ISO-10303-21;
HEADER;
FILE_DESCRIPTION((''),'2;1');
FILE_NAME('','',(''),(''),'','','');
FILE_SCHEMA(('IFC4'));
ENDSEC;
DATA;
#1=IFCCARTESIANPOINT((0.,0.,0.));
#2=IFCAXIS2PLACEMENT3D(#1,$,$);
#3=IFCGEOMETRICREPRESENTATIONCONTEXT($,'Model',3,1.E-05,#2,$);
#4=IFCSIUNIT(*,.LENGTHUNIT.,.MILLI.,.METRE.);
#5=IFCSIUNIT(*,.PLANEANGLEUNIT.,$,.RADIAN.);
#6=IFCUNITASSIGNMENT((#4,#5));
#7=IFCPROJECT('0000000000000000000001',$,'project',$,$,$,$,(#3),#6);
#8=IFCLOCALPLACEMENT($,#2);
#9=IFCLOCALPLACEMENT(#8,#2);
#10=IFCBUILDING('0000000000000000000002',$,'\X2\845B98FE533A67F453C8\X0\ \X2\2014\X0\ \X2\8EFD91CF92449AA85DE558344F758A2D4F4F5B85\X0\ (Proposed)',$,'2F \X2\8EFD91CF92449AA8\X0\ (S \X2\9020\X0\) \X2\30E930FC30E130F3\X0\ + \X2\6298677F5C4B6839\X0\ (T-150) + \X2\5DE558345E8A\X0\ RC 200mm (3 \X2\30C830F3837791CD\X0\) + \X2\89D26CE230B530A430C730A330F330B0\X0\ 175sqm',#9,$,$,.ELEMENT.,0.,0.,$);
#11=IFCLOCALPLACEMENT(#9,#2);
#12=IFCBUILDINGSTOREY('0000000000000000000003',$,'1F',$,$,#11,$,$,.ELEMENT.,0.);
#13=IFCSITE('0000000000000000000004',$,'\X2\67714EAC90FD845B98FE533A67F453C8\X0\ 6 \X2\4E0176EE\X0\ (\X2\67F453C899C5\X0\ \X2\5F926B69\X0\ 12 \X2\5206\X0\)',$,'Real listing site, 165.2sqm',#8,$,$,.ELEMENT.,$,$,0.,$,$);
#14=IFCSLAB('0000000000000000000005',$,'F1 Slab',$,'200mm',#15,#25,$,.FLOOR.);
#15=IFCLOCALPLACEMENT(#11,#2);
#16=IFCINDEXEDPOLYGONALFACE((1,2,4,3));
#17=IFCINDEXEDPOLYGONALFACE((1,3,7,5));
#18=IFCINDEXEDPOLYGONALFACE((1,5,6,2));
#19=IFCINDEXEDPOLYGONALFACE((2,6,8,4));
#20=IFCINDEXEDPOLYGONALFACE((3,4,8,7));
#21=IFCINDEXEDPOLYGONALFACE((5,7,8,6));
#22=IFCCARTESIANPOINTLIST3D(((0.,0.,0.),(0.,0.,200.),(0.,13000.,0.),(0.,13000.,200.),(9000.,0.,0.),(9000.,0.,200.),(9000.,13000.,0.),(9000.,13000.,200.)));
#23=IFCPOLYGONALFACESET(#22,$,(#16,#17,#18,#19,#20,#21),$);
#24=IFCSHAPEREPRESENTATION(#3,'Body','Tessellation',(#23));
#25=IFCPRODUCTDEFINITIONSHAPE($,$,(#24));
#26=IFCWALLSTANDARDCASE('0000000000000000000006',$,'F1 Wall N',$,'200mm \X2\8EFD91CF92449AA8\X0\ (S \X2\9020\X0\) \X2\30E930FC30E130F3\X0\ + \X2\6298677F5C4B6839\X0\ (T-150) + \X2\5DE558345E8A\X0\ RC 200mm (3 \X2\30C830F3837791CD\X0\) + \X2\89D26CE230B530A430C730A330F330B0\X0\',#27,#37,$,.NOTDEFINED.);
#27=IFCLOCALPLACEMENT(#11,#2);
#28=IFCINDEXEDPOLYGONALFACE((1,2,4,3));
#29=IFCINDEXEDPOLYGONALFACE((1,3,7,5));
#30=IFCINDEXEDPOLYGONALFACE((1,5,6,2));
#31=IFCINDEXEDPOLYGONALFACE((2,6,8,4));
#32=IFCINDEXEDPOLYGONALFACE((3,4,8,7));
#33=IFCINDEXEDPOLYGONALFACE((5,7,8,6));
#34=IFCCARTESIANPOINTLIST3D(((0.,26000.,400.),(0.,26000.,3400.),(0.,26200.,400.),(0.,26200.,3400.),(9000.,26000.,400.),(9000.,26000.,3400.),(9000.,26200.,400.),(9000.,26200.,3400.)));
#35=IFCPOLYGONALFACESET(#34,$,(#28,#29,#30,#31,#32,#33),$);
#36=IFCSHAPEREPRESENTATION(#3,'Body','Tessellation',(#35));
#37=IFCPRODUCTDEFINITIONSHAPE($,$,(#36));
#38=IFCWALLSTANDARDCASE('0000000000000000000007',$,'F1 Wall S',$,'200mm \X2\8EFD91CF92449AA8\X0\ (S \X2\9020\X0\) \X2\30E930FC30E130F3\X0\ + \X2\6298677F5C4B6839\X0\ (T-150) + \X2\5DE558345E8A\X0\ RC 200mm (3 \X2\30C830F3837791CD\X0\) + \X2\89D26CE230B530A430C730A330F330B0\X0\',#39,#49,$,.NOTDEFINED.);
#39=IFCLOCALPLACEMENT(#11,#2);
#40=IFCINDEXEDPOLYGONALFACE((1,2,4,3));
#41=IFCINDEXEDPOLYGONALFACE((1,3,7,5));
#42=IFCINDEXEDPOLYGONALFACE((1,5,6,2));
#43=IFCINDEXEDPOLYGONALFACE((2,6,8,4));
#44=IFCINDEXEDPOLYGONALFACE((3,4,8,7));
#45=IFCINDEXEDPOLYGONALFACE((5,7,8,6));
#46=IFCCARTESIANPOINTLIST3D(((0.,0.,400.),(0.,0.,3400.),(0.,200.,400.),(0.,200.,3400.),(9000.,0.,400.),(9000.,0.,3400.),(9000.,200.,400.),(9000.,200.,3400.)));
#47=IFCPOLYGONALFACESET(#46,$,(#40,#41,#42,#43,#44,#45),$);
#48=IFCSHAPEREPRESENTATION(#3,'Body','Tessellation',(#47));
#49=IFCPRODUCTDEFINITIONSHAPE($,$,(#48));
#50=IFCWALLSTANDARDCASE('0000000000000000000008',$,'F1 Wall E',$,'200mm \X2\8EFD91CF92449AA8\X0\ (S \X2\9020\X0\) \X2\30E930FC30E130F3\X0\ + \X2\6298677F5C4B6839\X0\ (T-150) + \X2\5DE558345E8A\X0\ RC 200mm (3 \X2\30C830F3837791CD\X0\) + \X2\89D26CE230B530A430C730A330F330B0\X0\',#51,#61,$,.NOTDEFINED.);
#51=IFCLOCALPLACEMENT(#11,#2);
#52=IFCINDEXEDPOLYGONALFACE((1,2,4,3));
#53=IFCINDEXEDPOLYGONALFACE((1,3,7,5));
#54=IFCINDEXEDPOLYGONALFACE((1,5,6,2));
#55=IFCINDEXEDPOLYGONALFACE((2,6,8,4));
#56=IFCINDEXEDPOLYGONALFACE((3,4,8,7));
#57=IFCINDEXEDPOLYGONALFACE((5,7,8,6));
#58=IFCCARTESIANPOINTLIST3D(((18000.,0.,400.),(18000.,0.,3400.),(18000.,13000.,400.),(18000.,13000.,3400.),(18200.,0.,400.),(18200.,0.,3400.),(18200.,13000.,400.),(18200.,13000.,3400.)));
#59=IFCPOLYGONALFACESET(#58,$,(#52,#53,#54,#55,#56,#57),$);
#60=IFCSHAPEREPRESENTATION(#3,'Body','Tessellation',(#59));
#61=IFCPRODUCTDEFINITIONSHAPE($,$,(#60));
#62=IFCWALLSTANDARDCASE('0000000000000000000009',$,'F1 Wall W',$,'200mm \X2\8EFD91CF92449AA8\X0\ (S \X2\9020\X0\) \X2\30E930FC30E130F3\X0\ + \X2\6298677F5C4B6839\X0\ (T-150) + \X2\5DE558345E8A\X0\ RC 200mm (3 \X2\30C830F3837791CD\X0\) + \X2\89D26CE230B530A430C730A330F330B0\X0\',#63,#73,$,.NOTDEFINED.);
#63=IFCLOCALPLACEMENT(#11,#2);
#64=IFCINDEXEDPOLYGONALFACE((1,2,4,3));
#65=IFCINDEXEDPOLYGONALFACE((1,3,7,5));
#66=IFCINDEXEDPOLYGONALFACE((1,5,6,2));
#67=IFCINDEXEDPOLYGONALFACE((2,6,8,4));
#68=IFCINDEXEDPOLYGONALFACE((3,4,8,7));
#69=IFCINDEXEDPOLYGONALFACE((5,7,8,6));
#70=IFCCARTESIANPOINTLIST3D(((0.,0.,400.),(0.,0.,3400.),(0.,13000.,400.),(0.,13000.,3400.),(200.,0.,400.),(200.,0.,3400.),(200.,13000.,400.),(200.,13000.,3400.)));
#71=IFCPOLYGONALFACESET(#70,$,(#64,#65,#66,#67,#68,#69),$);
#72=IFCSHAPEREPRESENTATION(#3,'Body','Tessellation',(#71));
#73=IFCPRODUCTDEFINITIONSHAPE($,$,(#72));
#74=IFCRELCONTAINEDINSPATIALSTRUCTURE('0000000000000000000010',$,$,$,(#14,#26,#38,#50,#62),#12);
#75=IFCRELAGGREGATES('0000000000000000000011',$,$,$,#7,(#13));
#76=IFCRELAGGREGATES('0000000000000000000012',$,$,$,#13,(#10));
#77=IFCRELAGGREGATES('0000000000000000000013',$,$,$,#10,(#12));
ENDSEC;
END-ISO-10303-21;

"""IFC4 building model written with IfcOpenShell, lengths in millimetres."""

from ifc_helpers import new_model, si_unit, frame, frame_2d, origin, place, context, project, spatial, rectangle, extrude, element, save


model = new_model("IFC4")

# Units and contexts
model_context = context("Model", 3, precision=1e-05, world=origin())
ifc_project = project(units=[si_unit("LENGTHUNIT", "METRE", prefix="MILLI"), si_unit("PLANEANGLEUNIT", "RADIAN")], contexts=[model_context])

# Site, building, storey
site_placement = place(None, origin())
site = spatial("IfcSite", under=ifc_project, at=site_placement, Name="東京都葛飾区柴又 6 丁目 (柴又駅 徒歩 12 分)", ObjectType="Real listing site, 165.2sqm", CompositionType="ELEMENT", RefElevation=0.0)
building_placement = place(site_placement, origin())
building = spatial("IfcBuilding", under=site, at=building_placement, Name="葛飾区柴又 — 軽量鉄骨工場併設住宅 (Proposed)", ObjectType="2F 軽量鉄骨 (S 造) ラーメン + 折板屋根 (T-150) + 工場床 RC 200mm (3 トン荷重) + 角波サイディング 175sqm", CompositionType="ELEMENT", ElevationOfRefHeight=0.0, ElevationOfTerrain=0.0)
storey_placement = place(building_placement, origin())
storey = spatial("IfcBuildingStorey", under=building, at=storey_placement, Name="1F", CompositionType="ELEMENT", Elevation=0.0)

# Slab
slab_placement = place(storey_placement, origin())
element("IfcSlab", 1, at=slab_placement, inside=storey, Name="F1 Slab", ObjectType="200mm", PredefinedType="FLOOR", context=model_context, shape_type="SweptSolid", body=[
    extrude(rectangle(XDim=9000.0, YDim=13000.0, at=frame_2d((4500.0, 6500.0))), origin(), (0.0, 0.0, 1.0), 200.0),
])

# Walls
wall_1_placement = place(storey_placement, frame((0.0, 13000.0, 200.0)))
element("IfcWallStandardCase", 2, at=wall_1_placement, inside=storey, Name="F1 Wall N", ObjectType="200mm 軽量鉄骨 (S 造) ラーメン + 折板屋根 (T-150) + 工場床 RC 200mm (3 トン荷重) + 角波サイディング", PredefinedType="NOTDEFINED", context=model_context, shape_type="SweptSolid", body=[
    extrude(rectangle(XDim=9000.0, YDim=200.0, at=frame_2d((4500.0, 100.0))), frame((0.0, 13000.0, 200.0)), (0.0, 0.0, 1.0), 3000.0),
])
wall_2_placement = place(storey_placement, frame((0.0, 0.0, 200.0)))
element("IfcWallStandardCase", 3, at=wall_2_placement, inside=storey, Name="F1 Wall S", ObjectType="200mm 軽量鉄骨 (S 造) ラーメン + 折板屋根 (T-150) + 工場床 RC 200mm (3 トン荷重) + 角波サイディング", PredefinedType="NOTDEFINED", context=model_context, shape_type="SweptSolid", body=[
    extrude(rectangle(XDim=9000.0, YDim=200.0, at=frame_2d((4500.0, 100.0))), frame((0.0, 0.0, 200.0)), (0.0, 0.0, 1.0), 3000.0),
])
wall_3_placement = place(storey_placement, frame((9000.0, 0.0, 200.0)))
element("IfcWallStandardCase", 4, at=wall_3_placement, inside=storey, Name="F1 Wall E", ObjectType="200mm 軽量鉄骨 (S 造) ラーメン + 折板屋根 (T-150) + 工場床 RC 200mm (3 トン荷重) + 角波サイディング", PredefinedType="NOTDEFINED", context=model_context, shape_type="SweptSolid", body=[
    extrude(rectangle(XDim=200.0, YDim=13000.0, at=frame_2d((100.0, 6500.0))), frame((9000.0, 0.0, 200.0)), (0.0, 0.0, 1.0), 3000.0),
])
wall_4_placement = place(storey_placement, frame((0.0, 0.0, 200.0)))
element("IfcWallStandardCase", 5, at=wall_4_placement, inside=storey, Name="F1 Wall W", ObjectType="200mm 軽量鉄骨 (S 造) ラーメン + 折板屋根 (T-150) + 工場床 RC 200mm (3 トン荷重) + 角波サイディング", PredefinedType="NOTDEFINED", context=model_context, shape_type="SweptSolid", body=[
    extrude(rectangle(XDim=200.0, YDim=13000.0, at=frame_2d((100.0, 6500.0))), frame((0.0, 0.0, 200.0)), (0.0, 0.0, 1.0), 3000.0),
])

save(model, "model.ifc")
